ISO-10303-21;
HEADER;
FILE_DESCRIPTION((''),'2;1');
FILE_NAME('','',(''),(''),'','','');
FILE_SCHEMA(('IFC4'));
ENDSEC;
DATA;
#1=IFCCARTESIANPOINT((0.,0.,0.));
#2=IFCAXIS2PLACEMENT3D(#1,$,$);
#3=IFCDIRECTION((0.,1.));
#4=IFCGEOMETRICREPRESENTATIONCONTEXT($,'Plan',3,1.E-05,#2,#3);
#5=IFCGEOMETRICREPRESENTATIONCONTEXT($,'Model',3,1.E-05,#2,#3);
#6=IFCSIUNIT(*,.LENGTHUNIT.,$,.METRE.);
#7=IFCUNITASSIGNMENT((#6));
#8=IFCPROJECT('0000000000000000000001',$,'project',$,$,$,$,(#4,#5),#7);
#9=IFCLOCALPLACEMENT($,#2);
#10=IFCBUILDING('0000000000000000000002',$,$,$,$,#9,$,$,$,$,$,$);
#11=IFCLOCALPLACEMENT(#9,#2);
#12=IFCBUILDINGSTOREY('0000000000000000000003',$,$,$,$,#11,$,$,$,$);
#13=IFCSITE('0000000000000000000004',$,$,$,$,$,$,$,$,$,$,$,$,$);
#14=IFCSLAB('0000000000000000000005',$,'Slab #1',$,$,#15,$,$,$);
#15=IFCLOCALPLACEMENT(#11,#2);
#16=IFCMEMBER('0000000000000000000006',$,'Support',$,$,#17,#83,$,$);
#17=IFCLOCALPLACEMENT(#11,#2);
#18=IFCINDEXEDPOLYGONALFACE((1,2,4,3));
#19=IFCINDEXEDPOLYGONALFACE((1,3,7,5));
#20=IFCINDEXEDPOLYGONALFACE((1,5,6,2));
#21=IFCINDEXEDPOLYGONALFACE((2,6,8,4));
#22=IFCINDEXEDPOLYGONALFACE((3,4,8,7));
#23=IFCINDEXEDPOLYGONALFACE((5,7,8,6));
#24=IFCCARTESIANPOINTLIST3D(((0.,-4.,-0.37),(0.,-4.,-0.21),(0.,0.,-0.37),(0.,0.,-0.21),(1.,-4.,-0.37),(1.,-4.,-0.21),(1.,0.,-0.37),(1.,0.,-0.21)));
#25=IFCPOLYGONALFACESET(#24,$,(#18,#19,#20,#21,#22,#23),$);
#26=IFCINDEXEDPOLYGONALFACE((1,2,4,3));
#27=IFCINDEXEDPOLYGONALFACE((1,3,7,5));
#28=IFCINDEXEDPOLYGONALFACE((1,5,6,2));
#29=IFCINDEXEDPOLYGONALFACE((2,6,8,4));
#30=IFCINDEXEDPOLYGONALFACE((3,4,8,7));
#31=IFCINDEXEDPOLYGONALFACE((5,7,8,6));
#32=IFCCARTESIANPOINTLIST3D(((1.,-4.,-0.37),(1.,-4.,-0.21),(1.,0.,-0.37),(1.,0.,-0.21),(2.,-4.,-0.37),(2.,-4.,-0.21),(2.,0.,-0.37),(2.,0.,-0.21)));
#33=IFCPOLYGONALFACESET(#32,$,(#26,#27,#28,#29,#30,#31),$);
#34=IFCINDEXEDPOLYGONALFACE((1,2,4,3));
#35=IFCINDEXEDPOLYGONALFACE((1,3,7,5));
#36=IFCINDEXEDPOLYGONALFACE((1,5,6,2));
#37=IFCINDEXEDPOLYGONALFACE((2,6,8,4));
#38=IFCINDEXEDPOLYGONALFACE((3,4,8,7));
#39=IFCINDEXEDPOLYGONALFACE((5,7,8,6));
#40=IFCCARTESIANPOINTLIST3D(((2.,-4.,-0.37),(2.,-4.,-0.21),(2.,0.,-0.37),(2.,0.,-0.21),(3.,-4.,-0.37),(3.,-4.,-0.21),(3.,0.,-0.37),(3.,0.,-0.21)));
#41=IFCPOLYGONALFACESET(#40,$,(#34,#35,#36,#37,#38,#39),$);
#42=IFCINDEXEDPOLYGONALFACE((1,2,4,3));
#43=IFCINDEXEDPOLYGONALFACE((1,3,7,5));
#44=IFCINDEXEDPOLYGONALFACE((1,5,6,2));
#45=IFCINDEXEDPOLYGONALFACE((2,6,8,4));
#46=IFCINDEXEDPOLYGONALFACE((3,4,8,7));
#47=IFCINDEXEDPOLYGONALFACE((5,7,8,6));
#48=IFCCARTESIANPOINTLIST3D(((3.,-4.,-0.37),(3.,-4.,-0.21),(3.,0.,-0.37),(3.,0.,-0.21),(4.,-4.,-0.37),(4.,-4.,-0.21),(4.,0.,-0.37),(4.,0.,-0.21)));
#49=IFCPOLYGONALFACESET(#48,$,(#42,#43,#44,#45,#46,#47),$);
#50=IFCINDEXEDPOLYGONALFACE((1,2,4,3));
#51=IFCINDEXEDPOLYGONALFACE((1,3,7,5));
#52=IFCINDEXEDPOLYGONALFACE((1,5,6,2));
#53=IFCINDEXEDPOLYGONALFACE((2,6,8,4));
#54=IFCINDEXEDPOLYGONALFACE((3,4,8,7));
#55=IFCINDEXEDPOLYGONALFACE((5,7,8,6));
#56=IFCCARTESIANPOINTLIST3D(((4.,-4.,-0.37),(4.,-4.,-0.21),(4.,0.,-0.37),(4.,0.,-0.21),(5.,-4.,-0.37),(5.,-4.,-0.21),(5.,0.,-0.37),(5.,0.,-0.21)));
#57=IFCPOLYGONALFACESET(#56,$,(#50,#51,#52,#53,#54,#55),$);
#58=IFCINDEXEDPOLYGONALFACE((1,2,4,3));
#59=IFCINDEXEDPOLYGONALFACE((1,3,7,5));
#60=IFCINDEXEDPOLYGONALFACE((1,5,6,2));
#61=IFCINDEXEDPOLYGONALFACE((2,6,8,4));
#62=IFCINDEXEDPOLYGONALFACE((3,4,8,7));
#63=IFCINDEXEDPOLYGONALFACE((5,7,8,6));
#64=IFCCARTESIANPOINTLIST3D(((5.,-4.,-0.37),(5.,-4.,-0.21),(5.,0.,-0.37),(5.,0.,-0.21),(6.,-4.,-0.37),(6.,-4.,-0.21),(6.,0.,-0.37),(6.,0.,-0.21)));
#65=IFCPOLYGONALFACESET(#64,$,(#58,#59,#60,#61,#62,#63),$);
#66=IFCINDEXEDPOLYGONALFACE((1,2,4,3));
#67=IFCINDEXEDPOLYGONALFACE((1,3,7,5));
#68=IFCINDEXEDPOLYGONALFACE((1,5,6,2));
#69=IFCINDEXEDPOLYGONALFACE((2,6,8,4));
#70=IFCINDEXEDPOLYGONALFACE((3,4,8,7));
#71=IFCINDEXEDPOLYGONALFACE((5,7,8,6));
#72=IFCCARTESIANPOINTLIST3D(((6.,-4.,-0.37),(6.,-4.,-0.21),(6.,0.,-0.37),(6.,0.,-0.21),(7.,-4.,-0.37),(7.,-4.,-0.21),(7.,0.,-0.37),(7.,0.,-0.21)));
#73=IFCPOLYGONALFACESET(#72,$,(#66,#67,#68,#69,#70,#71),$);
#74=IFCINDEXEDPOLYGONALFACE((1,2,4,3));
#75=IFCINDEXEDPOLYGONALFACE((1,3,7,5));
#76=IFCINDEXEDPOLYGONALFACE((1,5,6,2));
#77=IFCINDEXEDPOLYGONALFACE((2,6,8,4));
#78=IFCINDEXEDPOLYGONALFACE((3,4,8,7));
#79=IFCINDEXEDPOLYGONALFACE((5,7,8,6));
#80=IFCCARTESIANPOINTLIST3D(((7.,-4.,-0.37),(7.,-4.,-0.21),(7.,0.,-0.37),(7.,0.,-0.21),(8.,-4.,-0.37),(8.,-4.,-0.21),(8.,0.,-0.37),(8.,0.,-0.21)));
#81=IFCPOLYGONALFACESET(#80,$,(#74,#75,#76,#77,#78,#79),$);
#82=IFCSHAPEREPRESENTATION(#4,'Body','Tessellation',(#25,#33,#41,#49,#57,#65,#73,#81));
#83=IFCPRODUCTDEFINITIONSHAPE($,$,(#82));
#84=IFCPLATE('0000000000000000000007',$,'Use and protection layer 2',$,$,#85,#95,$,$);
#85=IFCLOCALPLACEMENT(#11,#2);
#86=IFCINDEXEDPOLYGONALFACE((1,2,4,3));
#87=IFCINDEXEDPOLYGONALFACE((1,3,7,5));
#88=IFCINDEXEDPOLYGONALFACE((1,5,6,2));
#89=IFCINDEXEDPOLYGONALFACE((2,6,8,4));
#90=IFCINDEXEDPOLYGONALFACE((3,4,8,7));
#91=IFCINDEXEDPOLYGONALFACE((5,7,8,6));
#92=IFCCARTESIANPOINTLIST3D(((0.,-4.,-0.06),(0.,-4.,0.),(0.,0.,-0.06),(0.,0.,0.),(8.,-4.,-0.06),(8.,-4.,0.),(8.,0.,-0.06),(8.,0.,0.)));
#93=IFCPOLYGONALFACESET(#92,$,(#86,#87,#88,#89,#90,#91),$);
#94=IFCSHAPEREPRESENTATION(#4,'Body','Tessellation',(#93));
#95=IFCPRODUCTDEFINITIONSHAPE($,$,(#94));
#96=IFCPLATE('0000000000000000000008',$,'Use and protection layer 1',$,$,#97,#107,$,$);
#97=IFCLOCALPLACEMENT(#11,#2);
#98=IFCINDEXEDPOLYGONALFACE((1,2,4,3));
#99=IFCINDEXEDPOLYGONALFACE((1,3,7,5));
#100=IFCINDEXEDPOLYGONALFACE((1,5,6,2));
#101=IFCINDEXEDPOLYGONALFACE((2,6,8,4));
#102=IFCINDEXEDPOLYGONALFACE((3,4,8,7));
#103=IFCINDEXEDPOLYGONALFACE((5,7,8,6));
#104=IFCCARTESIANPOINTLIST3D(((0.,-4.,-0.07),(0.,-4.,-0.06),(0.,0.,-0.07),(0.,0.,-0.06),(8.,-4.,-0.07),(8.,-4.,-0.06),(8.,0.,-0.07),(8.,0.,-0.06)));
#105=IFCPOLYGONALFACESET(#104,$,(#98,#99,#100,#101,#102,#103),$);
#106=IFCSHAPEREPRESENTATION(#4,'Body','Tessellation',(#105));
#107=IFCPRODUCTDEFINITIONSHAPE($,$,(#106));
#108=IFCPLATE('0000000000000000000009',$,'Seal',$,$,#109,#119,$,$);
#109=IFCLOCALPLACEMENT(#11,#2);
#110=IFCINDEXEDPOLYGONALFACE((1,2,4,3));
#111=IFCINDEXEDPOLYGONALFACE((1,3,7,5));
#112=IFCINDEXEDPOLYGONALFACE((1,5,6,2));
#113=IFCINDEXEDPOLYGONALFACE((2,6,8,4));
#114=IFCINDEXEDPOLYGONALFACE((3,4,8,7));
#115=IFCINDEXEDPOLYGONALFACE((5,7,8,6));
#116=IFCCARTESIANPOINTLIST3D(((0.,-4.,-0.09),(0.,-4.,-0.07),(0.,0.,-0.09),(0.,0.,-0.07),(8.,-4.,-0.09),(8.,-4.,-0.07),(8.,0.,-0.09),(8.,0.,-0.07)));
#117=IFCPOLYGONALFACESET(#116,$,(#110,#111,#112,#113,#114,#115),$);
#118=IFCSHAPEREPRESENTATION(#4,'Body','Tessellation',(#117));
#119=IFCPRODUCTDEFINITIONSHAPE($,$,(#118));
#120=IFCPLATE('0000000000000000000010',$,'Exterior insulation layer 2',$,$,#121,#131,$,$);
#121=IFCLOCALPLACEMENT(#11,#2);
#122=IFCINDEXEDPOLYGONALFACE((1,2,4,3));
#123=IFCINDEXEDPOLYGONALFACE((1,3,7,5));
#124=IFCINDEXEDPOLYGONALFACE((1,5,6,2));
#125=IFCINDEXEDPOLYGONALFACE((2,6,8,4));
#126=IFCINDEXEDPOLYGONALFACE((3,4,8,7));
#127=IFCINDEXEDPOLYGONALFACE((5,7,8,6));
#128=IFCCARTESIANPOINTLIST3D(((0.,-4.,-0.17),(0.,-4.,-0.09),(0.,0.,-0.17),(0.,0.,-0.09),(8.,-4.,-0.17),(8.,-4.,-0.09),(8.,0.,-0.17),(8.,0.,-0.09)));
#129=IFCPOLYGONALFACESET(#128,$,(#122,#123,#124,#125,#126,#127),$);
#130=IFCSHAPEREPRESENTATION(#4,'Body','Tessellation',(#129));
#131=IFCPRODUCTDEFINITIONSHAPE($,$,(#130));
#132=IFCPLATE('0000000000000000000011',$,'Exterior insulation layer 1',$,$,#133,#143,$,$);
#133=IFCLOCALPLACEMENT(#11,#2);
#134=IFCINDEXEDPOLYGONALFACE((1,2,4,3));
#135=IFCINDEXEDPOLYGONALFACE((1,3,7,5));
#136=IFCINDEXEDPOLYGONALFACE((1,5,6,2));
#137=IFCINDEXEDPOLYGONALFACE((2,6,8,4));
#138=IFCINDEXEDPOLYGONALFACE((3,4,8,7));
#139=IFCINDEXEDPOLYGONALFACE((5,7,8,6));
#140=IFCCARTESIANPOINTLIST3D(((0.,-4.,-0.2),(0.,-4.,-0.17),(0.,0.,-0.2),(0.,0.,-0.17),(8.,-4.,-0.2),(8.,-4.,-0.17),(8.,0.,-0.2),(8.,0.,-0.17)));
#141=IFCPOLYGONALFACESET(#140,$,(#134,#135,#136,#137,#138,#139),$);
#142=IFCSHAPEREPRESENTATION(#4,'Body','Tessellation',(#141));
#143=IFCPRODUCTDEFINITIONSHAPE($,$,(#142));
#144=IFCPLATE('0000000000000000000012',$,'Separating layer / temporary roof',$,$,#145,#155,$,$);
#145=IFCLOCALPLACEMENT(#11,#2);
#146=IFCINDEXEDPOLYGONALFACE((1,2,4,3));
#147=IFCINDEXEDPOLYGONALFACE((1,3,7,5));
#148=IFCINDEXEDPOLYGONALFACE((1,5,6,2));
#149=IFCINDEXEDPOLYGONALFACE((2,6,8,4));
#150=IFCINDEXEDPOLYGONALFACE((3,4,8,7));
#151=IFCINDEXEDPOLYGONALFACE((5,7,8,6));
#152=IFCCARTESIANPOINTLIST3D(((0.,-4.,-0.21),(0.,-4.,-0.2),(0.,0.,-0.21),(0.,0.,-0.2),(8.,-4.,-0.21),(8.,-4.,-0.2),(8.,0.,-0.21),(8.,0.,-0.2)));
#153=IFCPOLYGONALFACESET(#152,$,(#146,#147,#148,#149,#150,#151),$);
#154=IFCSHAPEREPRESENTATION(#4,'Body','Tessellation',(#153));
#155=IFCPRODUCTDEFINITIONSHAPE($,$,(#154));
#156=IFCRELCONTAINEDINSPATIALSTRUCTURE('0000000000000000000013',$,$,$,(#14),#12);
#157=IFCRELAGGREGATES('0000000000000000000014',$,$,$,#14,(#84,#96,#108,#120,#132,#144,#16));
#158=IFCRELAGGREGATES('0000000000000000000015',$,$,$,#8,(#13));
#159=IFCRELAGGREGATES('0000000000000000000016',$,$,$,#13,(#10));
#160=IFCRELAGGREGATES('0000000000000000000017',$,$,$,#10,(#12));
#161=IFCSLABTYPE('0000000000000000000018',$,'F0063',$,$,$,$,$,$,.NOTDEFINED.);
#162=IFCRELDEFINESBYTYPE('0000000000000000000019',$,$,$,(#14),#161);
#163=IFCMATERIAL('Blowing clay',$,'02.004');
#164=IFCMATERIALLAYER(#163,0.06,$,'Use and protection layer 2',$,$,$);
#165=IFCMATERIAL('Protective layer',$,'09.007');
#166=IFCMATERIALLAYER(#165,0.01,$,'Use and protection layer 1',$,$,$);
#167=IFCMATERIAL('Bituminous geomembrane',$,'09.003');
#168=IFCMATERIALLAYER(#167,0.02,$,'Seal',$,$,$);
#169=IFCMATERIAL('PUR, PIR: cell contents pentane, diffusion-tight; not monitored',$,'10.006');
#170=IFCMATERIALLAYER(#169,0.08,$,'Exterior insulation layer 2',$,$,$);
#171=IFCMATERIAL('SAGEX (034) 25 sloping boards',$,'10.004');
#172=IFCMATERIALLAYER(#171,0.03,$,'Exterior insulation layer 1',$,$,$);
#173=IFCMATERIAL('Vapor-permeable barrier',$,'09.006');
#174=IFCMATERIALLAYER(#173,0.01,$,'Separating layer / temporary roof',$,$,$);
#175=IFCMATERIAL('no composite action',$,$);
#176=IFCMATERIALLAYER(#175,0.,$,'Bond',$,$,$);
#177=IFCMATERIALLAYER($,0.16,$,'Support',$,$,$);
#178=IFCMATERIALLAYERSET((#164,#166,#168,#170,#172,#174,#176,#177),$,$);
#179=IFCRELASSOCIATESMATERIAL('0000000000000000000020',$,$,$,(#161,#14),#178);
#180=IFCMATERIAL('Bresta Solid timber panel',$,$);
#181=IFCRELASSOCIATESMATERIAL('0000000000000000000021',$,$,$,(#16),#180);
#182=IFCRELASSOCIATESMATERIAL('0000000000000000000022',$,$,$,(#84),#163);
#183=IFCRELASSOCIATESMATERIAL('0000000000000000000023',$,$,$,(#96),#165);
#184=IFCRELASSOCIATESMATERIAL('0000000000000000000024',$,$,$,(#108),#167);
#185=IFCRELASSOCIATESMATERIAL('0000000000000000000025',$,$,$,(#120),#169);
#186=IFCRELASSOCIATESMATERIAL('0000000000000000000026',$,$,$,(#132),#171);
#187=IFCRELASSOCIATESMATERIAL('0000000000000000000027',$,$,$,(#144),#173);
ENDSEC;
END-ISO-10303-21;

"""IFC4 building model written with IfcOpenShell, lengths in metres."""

from ifc_helpers import new_model, si_unit, direction, frame, frame_2d, origin, origin_with_axes, place, context, project, spatial, rectangle, extrude, material, layer, layer_set, type_object, element, aggregate, save


model = new_model("IFC4")

# Units and contexts
plan_context = context("Plan", 3, precision=1e-05, world=origin(), true_north=direction((0.0, 1.0)))
model_context = context("Model", 3, precision=1e-05, world=origin(), true_north=direction((0.0, 1.0)))
ifc_project = project(units=[si_unit("LENGTHUNIT", "METRE")], contexts=[plan_context, model_context])

# Site, building, storey
site = spatial("IfcSite", under=ifc_project)
building_placement = place(None, origin())
building = spatial("IfcBuilding", under=site, at=building_placement)
storey_placement = place(building_placement, origin())
storey = spatial("IfcBuildingStorey", under=building, at=storey_placement)

# Slab, member, plates
ifc_material_1 = material(Name="Blowing clay", Category="02.004")
ifc_layer_1 = layer(ifc_material_1, 0.06, Name="Use and protection layer 2")
ifc_material_2 = material(Name="Protective layer", Category="09.007")
ifc_layer_2 = layer(ifc_material_2, 0.01, Name="Use and protection layer 1")
ifc_material_3 = material(Name="Bituminous geomembrane", Category="09.003")
ifc_layer_3 = layer(ifc_material_3, 0.02, Name="Seal")
ifc_material_4 = material(Name="PUR, PIR: cell contents pentane, diffusion-tight; not monitored", Category="10.006")
ifc_layer_4 = layer(ifc_material_4, 0.08, Name="Exterior insulation layer 2")
ifc_material_5 = material(Name="SAGEX (034) 25 sloping boards", Category="10.004")
ifc_layer_5 = layer(ifc_material_5, 0.03, Name="Exterior insulation layer 1")
ifc_material_6 = material(Name="Vapor-permeable barrier", Category="09.006")
ifc_layer_6 = layer(ifc_material_6, 0.01, Name="Separating layer / temporary roof")
ifc_material_7 = material(Name="no composite action")
ifc_layer_7 = layer(ifc_material_7, 0.0, Name="Bond")
ifc_layer_8 = layer(None, 0.16, Name="Support")
ifc_layer_set = layer_set([ifc_layer_1, ifc_layer_2, ifc_layer_3, ifc_layer_4, ifc_layer_5, ifc_layer_6, ifc_layer_7, ifc_layer_8])
slab_type = type_object("IfcSlabType", Name="F0063", PredefinedType="NOTDEFINED", material=ifc_layer_set)
slab_placement = place(None, frame((0.0, 0.0, 0.0), z_axis=(0.0, 0.0, -1.0), x_axis=(1.0, 0.0, 0.0)))
slab = element("IfcSlab", 1, at=slab_placement, inside=storey, type_object=slab_type, material=ifc_layer_set, Name="Slab #1")
ifc_material_8 = material(Name="Bresta Solid timber panel")
member_placement = place(slab_placement, origin())
member = element("IfcMember", 2, at=member_placement, material=ifc_material_8, Name="Support", context=plan_context, shape_type="SweptSolid", body=[
    extrude(rectangle(XDim=1.0, YDim=0.16, at=frame_2d((0.5, 0.08), x_axis=(1.0, 0.0))), frame((0.0, 4.0, 0.21), z_axis=(0.0, -1.0, 0.0), x_axis=(1.0, 0.0, 0.0)), (0.0, 0.0, 1.0), 4.0),
    extrude(rectangle(XDim=1.0, YDim=0.16, at=frame_2d((0.5, 0.08), x_axis=(1.0, 0.0))), frame((1.0, 4.0, 0.21), z_axis=(0.0, -1.0, 0.0), x_axis=(1.0, 0.0, 0.0)), (0.0, 0.0, 1.0), 4.0),
    extrude(rectangle(XDim=1.0, YDim=0.16, at=frame_2d((0.5, 0.08), x_axis=(1.0, 0.0))), frame((2.0, 4.0, 0.21), z_axis=(0.0, -1.0, 0.0), x_axis=(1.0, 0.0, 0.0)), (0.0, 0.0, 1.0), 4.0),
    extrude(rectangle(XDim=1.0, YDim=0.16, at=frame_2d((0.5, 0.08), x_axis=(1.0, 0.0))), frame((3.0, 4.0, 0.21), z_axis=(0.0, -1.0, 0.0), x_axis=(1.0, 0.0, 0.0)), (0.0, 0.0, 1.0), 4.0),
    extrude(rectangle(XDim=1.0, YDim=0.16, at=frame_2d((0.5, 0.08), x_axis=(1.0, 0.0))), frame((4.0, 4.0, 0.21), z_axis=(0.0, -1.0, 0.0), x_axis=(1.0, 0.0, 0.0)), (0.0, 0.0, 1.0), 4.0),
    extrude(rectangle(XDim=1.0, YDim=0.16, at=frame_2d((0.5, 0.08), x_axis=(1.0, 0.0))), frame((5.0, 4.0, 0.21), z_axis=(0.0, -1.0, 0.0), x_axis=(1.0, 0.0, 0.0)), (0.0, 0.0, 1.0), 4.0),
    extrude(rectangle(XDim=1.0, YDim=0.16, at=frame_2d((0.5, 0.08), x_axis=(1.0, 0.0))), frame((6.0, 4.0, 0.21), z_axis=(0.0, -1.0, 0.0), x_axis=(1.0, 0.0, 0.0)), (0.0, 0.0, 1.0), 4.0),
    extrude(rectangle(XDim=1.0, YDim=0.16, at=frame_2d((0.5, 0.08), x_axis=(1.0, 0.0))), frame((7.0, 4.0, 0.21), z_axis=(0.0, -1.0, 0.0), x_axis=(1.0, 0.0, 0.0)), (0.0, 0.0, 1.0), 4.0),
])
plate_1_placement = place(slab_placement, origin())
plate_1 = element("IfcPlate", 3, at=plate_1_placement, material=ifc_material_1, Name="Use and protection layer 2", context=plan_context, shape_type="SweptSolid", body=[
    extrude(rectangle(XDim=8.0, YDim=4.0, at=frame_2d((4.0, 2.0), x_axis=(1.0, 0.0))), origin_with_axes(), (0.0, 0.0, 1.0), 0.06),
])
plate_2_placement = place(slab_placement, origin())
plate_2 = element("IfcPlate", 4, at=plate_2_placement, material=ifc_material_2, Name="Use and protection layer 1", context=plan_context, shape_type="SweptSolid", body=[
    extrude(rectangle(XDim=8.0, YDim=4.0, at=frame_2d((4.0, 2.0), x_axis=(1.0, 0.0))), frame((0.0, 0.0, 0.06), z_axis=(0.0, 0.0, 1.0), x_axis=(1.0, 0.0, 0.0)), (0.0, 0.0, 1.0), 0.01),
])
plate_3_placement = place(slab_placement, origin())
plate_3 = element("IfcPlate", 5, at=plate_3_placement, material=ifc_material_3, Name="Seal", context=plan_context, shape_type="SweptSolid", body=[
    extrude(rectangle(XDim=8.0, YDim=4.0, at=frame_2d((4.0, 2.0), x_axis=(1.0, 0.0))), frame((0.0, 0.0, 0.07), z_axis=(0.0, 0.0, 1.0), x_axis=(1.0, 0.0, 0.0)), (0.0, 0.0, 1.0), 0.02),
])
plate_4_placement = place(slab_placement, origin())
plate_4 = element("IfcPlate", 6, at=plate_4_placement, material=ifc_material_4, Name="Exterior insulation layer 2", context=plan_context, shape_type="SweptSolid", body=[
    extrude(rectangle(XDim=8.0, YDim=4.0, at=frame_2d((4.0, 2.0), x_axis=(1.0, 0.0))), frame((0.0, 0.0, 0.09), z_axis=(0.0, 0.0, 1.0), x_axis=(1.0, 0.0, 0.0)), (0.0, 0.0, 1.0), 0.08),
])
plate_5_placement = place(slab_placement, origin())
plate_5 = element("IfcPlate", 7, at=plate_5_placement, material=ifc_material_5, Name="Exterior insulation layer 1", context=plan_context, shape_type="SweptSolid", body=[
    extrude(rectangle(XDim=8.0, YDim=4.0, at=frame_2d((4.0, 2.0), x_axis=(1.0, 0.0))), frame((0.0, 0.0, 0.17), z_axis=(0.0, 0.0, 1.0), x_axis=(1.0, 0.0, 0.0)), (0.0, 0.0, 1.0), 0.03),
])
plate_6_placement = place(slab_placement, origin())
plate_6 = element("IfcPlate", 8, at=plate_6_placement, material=ifc_material_6, Name="Separating layer / temporary roof", context=plan_context, shape_type="SweptSolid", body=[
    extrude(rectangle(XDim=8.0, YDim=4.0, at=frame_2d((4.0, 2.0), x_axis=(1.0, 0.0))), frame((0.0, 0.0, 0.2), z_axis=(0.0, 0.0, 1.0), x_axis=(1.0, 0.0, 0.0)), (0.0, 0.0, 1.0), 0.01),
])
aggregate(slab, [plate_1, plate_2, plate_3, plate_4, plate_5, plate_6, member])

save(model, "model.ifc")
